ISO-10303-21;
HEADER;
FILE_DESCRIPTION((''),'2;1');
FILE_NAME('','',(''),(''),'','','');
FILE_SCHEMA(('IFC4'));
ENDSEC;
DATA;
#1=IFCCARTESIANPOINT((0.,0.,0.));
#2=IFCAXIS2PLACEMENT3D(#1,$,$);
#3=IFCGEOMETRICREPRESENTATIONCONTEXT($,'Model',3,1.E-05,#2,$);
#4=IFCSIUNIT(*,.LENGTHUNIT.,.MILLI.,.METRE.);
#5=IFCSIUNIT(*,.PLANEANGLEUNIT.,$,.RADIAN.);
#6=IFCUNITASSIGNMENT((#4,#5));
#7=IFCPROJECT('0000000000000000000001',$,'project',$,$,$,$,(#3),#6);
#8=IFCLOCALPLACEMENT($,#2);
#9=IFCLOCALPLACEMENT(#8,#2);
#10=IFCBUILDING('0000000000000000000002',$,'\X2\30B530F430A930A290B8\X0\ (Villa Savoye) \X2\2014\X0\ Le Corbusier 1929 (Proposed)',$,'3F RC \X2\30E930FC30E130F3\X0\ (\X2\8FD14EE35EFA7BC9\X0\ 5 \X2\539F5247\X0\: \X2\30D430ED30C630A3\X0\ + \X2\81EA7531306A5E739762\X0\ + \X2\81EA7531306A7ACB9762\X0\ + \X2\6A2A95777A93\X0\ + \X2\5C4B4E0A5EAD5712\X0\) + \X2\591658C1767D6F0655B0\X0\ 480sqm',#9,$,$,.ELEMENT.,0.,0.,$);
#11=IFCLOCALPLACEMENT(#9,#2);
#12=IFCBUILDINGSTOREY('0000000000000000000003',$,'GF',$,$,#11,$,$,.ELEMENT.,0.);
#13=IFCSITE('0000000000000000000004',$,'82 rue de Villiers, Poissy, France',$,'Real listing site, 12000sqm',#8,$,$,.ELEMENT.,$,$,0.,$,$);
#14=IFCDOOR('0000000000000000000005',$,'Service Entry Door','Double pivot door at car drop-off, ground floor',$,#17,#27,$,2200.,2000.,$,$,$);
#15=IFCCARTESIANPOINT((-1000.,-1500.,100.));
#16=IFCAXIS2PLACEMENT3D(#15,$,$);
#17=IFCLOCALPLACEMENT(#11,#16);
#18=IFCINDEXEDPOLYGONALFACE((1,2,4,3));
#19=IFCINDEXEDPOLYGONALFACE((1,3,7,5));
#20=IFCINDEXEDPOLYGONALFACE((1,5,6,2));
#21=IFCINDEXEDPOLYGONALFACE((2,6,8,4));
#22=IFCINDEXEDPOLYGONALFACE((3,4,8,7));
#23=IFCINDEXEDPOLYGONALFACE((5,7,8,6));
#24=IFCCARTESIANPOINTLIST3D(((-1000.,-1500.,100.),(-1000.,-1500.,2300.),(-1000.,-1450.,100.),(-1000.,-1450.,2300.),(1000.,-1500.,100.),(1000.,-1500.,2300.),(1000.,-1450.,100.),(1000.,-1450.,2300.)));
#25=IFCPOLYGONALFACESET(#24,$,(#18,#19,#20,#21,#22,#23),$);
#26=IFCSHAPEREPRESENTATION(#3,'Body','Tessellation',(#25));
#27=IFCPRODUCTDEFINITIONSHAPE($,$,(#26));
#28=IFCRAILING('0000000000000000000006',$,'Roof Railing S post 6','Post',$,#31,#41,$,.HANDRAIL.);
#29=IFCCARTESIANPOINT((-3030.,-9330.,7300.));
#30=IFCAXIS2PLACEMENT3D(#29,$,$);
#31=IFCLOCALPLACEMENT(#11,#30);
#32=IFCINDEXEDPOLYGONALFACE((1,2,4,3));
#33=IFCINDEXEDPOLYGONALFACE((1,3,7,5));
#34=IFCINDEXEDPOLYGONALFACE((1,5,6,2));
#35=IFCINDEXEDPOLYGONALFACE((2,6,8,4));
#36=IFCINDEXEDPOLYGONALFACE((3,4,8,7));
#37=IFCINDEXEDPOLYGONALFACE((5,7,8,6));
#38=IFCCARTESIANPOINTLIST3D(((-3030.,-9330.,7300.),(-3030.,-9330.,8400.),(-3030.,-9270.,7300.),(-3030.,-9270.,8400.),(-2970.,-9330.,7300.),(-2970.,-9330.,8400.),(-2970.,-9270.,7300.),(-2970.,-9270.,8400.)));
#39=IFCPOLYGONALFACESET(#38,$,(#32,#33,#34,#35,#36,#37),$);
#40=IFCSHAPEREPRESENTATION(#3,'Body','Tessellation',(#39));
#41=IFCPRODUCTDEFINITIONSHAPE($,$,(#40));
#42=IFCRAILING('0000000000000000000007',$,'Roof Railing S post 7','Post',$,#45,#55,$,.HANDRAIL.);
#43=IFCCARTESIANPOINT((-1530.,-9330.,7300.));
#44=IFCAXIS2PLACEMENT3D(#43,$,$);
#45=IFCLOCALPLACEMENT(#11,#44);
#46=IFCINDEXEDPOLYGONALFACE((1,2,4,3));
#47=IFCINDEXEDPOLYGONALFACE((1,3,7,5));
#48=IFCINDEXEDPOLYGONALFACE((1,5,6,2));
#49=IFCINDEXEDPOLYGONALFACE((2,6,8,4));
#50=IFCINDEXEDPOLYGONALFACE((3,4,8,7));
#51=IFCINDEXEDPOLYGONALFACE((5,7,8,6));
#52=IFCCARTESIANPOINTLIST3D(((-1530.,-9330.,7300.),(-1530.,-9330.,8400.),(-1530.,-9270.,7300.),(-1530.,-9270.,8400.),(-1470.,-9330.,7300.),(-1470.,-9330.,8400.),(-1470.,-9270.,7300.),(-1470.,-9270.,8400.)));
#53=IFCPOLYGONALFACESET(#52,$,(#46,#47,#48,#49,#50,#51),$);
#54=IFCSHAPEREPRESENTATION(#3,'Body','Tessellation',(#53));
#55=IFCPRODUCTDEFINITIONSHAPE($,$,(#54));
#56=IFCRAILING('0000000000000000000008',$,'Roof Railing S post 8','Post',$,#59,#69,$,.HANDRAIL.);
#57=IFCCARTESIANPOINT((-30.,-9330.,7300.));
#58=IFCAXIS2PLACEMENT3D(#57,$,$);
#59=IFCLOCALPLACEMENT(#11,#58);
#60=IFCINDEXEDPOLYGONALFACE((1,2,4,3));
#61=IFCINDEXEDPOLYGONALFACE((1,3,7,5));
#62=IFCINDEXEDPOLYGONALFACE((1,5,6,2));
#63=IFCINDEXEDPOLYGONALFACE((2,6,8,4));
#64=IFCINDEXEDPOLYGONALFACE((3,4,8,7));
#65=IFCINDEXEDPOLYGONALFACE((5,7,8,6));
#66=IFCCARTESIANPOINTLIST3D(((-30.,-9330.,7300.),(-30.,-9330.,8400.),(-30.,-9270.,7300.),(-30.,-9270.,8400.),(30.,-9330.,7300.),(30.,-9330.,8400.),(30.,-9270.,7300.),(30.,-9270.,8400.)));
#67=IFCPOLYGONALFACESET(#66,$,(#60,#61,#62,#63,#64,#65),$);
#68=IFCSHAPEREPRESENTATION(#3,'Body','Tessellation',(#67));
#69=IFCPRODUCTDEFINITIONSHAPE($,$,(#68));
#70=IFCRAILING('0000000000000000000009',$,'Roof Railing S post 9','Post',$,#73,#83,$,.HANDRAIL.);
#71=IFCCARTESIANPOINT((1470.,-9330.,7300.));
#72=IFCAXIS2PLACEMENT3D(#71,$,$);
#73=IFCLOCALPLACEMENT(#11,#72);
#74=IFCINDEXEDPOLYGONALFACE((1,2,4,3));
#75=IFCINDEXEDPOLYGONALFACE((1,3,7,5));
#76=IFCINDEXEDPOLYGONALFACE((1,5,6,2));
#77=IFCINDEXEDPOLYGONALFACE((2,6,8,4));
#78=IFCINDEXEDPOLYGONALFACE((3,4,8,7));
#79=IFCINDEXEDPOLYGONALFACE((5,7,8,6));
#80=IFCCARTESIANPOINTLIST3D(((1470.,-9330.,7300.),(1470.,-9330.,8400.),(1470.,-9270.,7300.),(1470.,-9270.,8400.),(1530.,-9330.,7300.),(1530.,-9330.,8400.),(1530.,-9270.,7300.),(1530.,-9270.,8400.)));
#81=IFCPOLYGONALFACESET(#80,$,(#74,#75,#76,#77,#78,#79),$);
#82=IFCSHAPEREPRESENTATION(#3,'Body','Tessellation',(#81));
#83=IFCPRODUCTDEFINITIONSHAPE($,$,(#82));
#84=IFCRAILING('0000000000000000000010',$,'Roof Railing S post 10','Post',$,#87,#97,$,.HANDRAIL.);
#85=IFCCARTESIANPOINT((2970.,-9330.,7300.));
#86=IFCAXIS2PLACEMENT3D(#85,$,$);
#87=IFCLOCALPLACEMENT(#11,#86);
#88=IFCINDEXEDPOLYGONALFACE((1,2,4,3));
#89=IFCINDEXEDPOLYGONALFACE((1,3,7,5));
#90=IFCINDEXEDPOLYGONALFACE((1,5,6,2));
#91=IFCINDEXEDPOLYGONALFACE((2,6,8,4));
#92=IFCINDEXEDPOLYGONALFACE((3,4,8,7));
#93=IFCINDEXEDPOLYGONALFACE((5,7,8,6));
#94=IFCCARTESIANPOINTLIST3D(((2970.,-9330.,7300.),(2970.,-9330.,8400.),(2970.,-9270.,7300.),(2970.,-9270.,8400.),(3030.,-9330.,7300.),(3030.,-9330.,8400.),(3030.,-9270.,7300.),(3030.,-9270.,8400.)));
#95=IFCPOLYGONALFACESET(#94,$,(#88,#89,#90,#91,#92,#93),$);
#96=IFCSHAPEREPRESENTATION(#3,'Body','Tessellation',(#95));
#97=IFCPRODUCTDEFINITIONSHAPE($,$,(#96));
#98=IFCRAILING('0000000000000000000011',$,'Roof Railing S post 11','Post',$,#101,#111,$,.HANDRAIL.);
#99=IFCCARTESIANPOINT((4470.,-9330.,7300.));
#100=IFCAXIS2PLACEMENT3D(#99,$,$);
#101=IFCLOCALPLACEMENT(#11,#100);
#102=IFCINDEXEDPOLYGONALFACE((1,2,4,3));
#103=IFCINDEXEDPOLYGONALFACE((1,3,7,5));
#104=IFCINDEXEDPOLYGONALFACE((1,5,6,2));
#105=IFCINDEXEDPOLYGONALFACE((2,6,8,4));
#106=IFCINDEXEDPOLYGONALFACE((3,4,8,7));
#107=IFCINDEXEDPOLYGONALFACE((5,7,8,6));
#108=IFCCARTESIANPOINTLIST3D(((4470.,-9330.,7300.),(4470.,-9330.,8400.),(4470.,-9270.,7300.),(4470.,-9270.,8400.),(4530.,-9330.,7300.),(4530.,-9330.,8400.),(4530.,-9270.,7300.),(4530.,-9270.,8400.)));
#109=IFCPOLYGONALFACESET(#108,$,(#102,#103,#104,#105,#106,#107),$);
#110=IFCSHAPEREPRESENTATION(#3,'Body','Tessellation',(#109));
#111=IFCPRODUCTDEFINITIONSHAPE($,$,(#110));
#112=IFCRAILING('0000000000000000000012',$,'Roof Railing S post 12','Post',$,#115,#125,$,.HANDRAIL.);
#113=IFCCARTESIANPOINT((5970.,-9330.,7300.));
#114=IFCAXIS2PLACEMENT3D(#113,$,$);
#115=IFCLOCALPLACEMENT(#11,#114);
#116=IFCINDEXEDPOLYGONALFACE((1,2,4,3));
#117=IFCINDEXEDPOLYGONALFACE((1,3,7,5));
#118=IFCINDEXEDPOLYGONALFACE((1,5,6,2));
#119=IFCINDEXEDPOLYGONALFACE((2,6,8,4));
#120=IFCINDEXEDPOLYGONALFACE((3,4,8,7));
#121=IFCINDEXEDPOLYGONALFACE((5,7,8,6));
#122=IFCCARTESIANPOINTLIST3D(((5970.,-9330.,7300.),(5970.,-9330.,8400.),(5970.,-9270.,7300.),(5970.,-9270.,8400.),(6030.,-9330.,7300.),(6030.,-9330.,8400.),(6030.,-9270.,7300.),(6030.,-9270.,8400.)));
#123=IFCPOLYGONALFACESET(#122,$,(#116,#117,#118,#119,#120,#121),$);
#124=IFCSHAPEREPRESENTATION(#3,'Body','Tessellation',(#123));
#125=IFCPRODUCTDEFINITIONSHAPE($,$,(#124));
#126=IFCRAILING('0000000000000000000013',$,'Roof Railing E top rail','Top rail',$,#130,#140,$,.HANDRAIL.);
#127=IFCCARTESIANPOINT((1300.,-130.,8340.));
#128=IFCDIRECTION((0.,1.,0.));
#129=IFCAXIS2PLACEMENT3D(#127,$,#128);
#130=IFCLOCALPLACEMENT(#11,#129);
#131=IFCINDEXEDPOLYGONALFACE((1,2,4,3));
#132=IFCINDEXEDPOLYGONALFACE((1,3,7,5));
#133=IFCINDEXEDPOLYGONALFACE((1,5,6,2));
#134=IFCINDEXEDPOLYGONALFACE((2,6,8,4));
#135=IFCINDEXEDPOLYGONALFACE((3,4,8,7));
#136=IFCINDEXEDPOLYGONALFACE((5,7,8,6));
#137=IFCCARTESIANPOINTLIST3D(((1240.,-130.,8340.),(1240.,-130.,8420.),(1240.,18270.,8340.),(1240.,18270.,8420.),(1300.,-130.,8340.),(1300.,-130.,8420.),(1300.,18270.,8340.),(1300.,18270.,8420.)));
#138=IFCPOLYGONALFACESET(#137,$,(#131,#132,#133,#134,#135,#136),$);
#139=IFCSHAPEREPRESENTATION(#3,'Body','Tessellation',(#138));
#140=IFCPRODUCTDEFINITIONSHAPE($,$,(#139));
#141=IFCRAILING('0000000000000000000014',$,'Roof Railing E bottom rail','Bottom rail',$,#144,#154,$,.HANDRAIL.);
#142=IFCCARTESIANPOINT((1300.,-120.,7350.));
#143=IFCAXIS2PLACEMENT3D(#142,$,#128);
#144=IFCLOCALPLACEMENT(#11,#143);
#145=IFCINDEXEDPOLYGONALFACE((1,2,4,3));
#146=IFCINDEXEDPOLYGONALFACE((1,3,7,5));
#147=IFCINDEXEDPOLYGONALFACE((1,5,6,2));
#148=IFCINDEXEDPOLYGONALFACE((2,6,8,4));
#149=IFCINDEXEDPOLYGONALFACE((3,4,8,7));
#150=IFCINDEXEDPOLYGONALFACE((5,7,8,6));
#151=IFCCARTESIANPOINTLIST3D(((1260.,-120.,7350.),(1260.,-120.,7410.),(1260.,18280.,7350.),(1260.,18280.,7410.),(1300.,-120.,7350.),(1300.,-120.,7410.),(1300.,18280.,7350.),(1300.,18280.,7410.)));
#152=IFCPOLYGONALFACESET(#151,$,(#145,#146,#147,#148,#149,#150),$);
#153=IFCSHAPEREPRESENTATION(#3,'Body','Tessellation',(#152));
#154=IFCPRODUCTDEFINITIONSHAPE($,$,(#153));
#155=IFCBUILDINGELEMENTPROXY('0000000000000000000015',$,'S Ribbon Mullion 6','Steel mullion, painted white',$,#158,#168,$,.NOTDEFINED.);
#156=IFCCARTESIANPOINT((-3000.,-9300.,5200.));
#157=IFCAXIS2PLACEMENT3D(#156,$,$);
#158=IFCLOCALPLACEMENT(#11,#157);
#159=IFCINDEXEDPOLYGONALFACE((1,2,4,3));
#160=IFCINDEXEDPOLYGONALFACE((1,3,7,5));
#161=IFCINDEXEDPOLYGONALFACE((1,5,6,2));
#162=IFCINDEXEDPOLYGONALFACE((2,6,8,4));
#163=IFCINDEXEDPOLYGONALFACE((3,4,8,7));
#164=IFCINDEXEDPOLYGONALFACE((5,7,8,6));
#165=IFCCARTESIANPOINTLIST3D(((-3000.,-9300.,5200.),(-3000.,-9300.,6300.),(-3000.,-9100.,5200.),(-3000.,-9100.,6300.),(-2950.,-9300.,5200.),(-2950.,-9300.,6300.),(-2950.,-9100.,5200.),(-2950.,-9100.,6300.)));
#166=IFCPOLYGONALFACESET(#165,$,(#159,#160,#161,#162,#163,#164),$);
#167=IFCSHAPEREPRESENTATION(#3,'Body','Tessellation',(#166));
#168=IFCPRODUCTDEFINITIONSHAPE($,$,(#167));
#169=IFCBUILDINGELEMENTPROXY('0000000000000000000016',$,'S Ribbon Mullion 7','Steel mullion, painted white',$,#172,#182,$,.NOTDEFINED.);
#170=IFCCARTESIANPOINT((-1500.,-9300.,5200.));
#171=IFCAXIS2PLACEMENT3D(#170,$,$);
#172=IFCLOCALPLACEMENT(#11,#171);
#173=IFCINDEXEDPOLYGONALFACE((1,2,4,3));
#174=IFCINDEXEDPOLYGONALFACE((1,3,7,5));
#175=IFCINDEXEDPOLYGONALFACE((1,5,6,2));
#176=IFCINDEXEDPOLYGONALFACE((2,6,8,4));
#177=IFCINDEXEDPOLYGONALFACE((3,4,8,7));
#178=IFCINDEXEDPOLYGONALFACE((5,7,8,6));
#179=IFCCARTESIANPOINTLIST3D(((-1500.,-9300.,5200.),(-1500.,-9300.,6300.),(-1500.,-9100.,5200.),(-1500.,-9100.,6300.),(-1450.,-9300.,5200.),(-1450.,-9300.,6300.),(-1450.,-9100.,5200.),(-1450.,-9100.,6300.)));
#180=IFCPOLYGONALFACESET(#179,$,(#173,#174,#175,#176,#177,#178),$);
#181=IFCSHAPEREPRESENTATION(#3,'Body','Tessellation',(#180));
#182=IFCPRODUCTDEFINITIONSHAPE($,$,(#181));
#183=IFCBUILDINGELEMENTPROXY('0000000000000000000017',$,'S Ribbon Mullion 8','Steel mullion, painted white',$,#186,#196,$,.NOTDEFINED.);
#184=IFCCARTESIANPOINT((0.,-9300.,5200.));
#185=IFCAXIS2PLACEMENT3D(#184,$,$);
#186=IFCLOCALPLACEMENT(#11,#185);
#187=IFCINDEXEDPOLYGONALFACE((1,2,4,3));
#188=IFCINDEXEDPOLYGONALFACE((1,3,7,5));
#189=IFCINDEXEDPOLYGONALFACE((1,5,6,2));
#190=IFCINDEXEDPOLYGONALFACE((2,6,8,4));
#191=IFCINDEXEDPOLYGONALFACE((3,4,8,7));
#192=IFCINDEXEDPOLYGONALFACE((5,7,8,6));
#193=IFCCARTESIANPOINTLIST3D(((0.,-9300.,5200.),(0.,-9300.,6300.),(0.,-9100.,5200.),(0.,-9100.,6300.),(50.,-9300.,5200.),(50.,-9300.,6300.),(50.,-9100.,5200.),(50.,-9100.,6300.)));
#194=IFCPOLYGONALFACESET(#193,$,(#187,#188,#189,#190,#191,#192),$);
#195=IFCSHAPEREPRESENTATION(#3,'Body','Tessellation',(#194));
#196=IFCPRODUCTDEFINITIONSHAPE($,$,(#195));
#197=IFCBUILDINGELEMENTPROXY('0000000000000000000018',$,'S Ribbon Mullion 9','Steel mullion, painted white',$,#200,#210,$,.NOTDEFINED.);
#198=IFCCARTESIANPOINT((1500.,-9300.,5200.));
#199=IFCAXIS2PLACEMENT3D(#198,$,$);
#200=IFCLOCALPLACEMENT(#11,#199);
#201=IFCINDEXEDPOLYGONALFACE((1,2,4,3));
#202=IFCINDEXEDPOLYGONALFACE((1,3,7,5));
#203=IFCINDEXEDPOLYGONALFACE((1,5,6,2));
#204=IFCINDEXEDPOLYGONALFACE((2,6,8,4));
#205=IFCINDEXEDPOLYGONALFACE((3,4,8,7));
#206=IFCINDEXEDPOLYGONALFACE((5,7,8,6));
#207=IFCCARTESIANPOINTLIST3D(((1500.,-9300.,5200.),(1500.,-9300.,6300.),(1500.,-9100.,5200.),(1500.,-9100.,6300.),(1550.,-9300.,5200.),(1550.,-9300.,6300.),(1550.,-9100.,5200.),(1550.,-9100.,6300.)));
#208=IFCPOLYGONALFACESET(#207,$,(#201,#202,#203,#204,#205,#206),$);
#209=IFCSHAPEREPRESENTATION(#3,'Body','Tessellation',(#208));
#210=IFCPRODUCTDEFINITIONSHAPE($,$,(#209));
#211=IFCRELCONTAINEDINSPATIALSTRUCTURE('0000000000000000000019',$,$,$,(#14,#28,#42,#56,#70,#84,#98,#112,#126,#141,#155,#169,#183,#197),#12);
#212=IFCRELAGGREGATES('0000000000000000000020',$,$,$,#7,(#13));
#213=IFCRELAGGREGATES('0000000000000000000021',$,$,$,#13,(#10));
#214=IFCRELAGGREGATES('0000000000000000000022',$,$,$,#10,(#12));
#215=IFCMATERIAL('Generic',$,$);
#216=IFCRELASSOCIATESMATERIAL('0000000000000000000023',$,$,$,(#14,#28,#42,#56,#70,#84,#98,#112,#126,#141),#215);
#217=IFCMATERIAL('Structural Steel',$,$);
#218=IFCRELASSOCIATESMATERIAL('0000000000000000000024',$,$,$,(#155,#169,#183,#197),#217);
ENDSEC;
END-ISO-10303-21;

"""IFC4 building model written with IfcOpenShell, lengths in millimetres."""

from ifc_helpers import new_model, si_unit, frame, frame_2d, origin, place, context, project, spatial, rectangle, extrude, material, element, save


model = new_model("IFC4")

# Units and contexts
model_context = context("Model", 3, precision=1e-05, world=origin())
ifc_project = project(units=[si_unit("LENGTHUNIT", "METRE", prefix="MILLI"), si_unit("PLANEANGLEUNIT", "RADIAN")], contexts=[model_context])

# Site, building, storey
site_placement = place(None, origin())
site = spatial("IfcSite", under=ifc_project, at=site_placement, Name="82 rue de Villiers, Poissy, France", ObjectType="Real listing site, 12000sqm", CompositionType="ELEMENT", RefElevation=0.0)
building_placement = place(site_placement, origin())
building = spatial("IfcBuilding", under=site, at=building_placement, Name="サヴォア邸 (Villa Savoye) — Le Corbusier 1929 (Proposed)", ObjectType="3F RC ラーメン (近代建築 5 原則: ピロティ + 自由な平面 + 自由な立面 + 横長窓 + 屋上庭園) + 外壁白漆喰 480sqm", CompositionType="ELEMENT", ElevationOfRefHeight=0.0, ElevationOfTerrain=0.0)
storey_placement = place(building_placement, origin())
storey = spatial("IfcBuildingStorey", under=building, at=storey_placement, Name="GF", CompositionType="ELEMENT", Elevation=0.0)

# Shared definitions
ifc_material_1 = material(Name="Generic")

# Door
door_placement = place(storey_placement, frame((-1000.0, -1500.0, 100.0)))
element("IfcDoor", 1, at=door_placement, inside=storey, material=ifc_material_1, Name="Service Entry Door", Description="Double pivot door at car drop-off, ground floor", OverallHeight=2200.0, OverallWidth=2000.0, context=model_context, shape_type="SweptSolid", body=[
    extrude(rectangle(XDim=2000.0, YDim=50.0, at=frame_2d((1000.0, 25.0))), frame((-1000.0, -1500.0, 100.0)), (0.0, 0.0, 1.0), 2200.0),
])

# Railings
railing_1_placement = place(storey_placement, frame((-3030.0, -9330.0, 7300.0)))
element("IfcRailing", 2, at=railing_1_placement, inside=storey, material=ifc_material_1, Name="Roof Railing S post 6", Description="Post", PredefinedType="HANDRAIL", context=model_context, shape_type="SweptSolid", body=[
    extrude(rectangle(XDim=60.0, YDim=60.0, at=frame_2d((30.0, 30.0))), frame((-3030.0, -9330.0, 7300.0)), (0.0, 0.0, 1.0), 1100.0),
])
railing_2_placement = place(storey_placement, frame((-1530.0, -9330.0, 7300.0)))
element("IfcRailing", 3, at=railing_2_placement, inside=storey, material=ifc_material_1, Name="Roof Railing S post 7", Description="Post", PredefinedType="HANDRAIL", context=model_context, shape_type="SweptSolid", body=[
    extrude(rectangle(XDim=60.0, YDim=60.0, at=frame_2d((30.0, 30.0))), frame((-1530.0, -9330.0, 7300.0)), (0.0, 0.0, 1.0), 1100.0),
])
railing_3_placement = place(storey_placement, frame((-30.0, -9330.0, 7300.0)))
element("IfcRailing", 4, at=railing_3_placement, inside=storey, material=ifc_material_1, Name="Roof Railing S post 8", Description="Post", PredefinedType="HANDRAIL", context=model_context, shape_type="SweptSolid", body=[
    extrude(rectangle(XDim=60.0, YDim=60.0, at=frame_2d((30.0, 30.0))), frame((-30.0, -9330.0, 7300.0)), (0.0, 0.0, 1.0), 1100.0),
])
railing_4_placement = place(storey_placement, frame((1470.0, -9330.0, 7300.0)))
element("IfcRailing", 5, at=railing_4_placement, inside=storey, material=ifc_material_1, Name="Roof Railing S post 9", Description="Post", PredefinedType="HANDRAIL", context=model_context, shape_type="SweptSolid", body=[
    extrude(rectangle(XDim=60.0, YDim=60.0, at=frame_2d((30.0, 30.0))), frame((1470.0, -9330.0, 7300.0)), (0.0, 0.0, 1.0), 1100.0),
])
railing_5_placement = place(storey_placement, frame((2970.0, -9330.0, 7300.0)))
element("IfcRailing", 6, at=railing_5_placement, inside=storey, material=ifc_material_1, Name="Roof Railing S post 10", Description="Post", PredefinedType="HANDRAIL", context=model_context, shape_type="SweptSolid", body=[
    extrude(rectangle(XDim=60.0, YDim=60.0, at=frame_2d((30.0, 30.0))), frame((2970.0, -9330.0, 7300.0)), (0.0, 0.0, 1.0), 1100.0),
])
railing_6_placement = place(storey_placement, frame((4470.0, -9330.0, 7300.0)))
element("IfcRailing", 7, at=railing_6_placement, inside=storey, material=ifc_material_1, Name="Roof Railing S post 11", Description="Post", PredefinedType="HANDRAIL", context=model_context, shape_type="SweptSolid", body=[
    extrude(rectangle(XDim=60.0, YDim=60.0, at=frame_2d((30.0, 30.0))), frame((4470.0, -9330.0, 7300.0)), (0.0, 0.0, 1.0), 1100.0),
])
railing_7_placement = place(storey_placement, frame((5970.0, -9330.0, 7300.0)))
element("IfcRailing", 8, at=railing_7_placement, inside=storey, material=ifc_material_1, Name="Roof Railing S post 12", Description="Post", PredefinedType="HANDRAIL", context=model_context, shape_type="SweptSolid", body=[
    extrude(rectangle(XDim=60.0, YDim=60.0, at=frame_2d((30.0, 30.0))), frame((5970.0, -9330.0, 7300.0)), (0.0, 0.0, 1.0), 1100.0),
])
railing_8_placement = place(storey_placement, frame((1300.0, -130.0, 8340.0), x_axis=(0.0, 1.0, 0.0)))
element("IfcRailing", 9, at=railing_8_placement, inside=storey, material=ifc_material_1, Name="Roof Railing E top rail", Description="Top rail", PredefinedType="HANDRAIL", context=model_context, shape_type="SweptSolid", body=[
    extrude(rectangle(XDim=18400.0, YDim=60.0, at=frame_2d((9200.0, 30.0))), frame((1300.0, -130.0, 8340.0), x_axis=(0.0, 1.0, 0.0)), (0.0, 0.0, 1.0), 80.0),
])
railing_9_placement = place(storey_placement, frame((1300.0, -120.0, 7350.0), x_axis=(0.0, 1.0, 0.0)))
element("IfcRailing", 10, at=railing_9_placement, inside=storey, material=ifc_material_1, Name="Roof Railing E bottom rail", Description="Bottom rail", PredefinedType="HANDRAIL", context=model_context, shape_type="SweptSolid", body=[
    extrude(rectangle(XDim=18400.0, YDim=40.0, at=frame_2d((9200.0, 20.0))), frame((1300.0, -120.0, 7350.0), x_axis=(0.0, 1.0, 0.0)), (0.0, 0.0, 1.0), 60.0),
])

# Building element proxies
ifc_material_2 = material(Name="Structural Steel")
proxy_1_placement = place(storey_placement, frame((-3000.0, -9300.0, 5200.0)))
element("IfcBuildingElementProxy", 11, at=proxy_1_placement, inside=storey, material=ifc_material_2, Name="S Ribbon Mullion 6", Description="Steel mullion, painted white", PredefinedType="NOTDEFINED", context=model_context, shape_type="SweptSolid", body=[
    extrude(rectangle(XDim=50.0, YDim=200.0, at=frame_2d((25.0, 100.0))), frame((-3000.0, -9300.0, 5200.0)), (0.0, 0.0, 1.0), 1100.0),
])
proxy_2_placement = place(storey_placement, frame((-1500.0, -9300.0, 5200.0)))
element("IfcBuildingElementProxy", 12, at=proxy_2_placement, inside=storey, material=ifc_material_2, Name="S Ribbon Mullion 7", Description="Steel mullion, painted white", PredefinedType="NOTDEFINED", context=model_context, shape_type="SweptSolid", body=[
    extrude(rectangle(XDim=50.0, YDim=200.0, at=frame_2d((25.0, 100.0))), frame((-1500.0, -9300.0, 5200.0)), (0.0, 0.0, 1.0), 1100.0),
])
proxy_3_placement = place(storey_placement, frame((0.0, -9300.0, 5200.0)))
element("IfcBuildingElementProxy", 13, at=proxy_3_placement, inside=storey, material=ifc_material_2, Name="S Ribbon Mullion 8", Description="Steel mullion, painted white", PredefinedType="NOTDEFINED", context=model_context, shape_type="SweptSolid", body=[
    extrude(rectangle(XDim=50.0, YDim=200.0, at=frame_2d((25.0, 100.0))), frame((0.0, -9300.0, 5200.0)), (0.0, 0.0, 1.0), 1100.0),
])
proxy_4_placement = place(storey_placement, frame((1500.0, -9300.0, 5200.0)))
element("IfcBuildingElementProxy", 14, at=proxy_4_placement, inside=storey, material=ifc_material_2, Name="S Ribbon Mullion 9", Description="Steel mullion, painted white", PredefinedType="NOTDEFINED", context=model_context, shape_type="SweptSolid", body=[
    extrude(rectangle(XDim=50.0, YDim=200.0, at=frame_2d((25.0, 100.0))), frame((1500.0, -9300.0, 5200.0)), (0.0, 0.0, 1.0), 1100.0),
])

save(model, "model.ifc")
